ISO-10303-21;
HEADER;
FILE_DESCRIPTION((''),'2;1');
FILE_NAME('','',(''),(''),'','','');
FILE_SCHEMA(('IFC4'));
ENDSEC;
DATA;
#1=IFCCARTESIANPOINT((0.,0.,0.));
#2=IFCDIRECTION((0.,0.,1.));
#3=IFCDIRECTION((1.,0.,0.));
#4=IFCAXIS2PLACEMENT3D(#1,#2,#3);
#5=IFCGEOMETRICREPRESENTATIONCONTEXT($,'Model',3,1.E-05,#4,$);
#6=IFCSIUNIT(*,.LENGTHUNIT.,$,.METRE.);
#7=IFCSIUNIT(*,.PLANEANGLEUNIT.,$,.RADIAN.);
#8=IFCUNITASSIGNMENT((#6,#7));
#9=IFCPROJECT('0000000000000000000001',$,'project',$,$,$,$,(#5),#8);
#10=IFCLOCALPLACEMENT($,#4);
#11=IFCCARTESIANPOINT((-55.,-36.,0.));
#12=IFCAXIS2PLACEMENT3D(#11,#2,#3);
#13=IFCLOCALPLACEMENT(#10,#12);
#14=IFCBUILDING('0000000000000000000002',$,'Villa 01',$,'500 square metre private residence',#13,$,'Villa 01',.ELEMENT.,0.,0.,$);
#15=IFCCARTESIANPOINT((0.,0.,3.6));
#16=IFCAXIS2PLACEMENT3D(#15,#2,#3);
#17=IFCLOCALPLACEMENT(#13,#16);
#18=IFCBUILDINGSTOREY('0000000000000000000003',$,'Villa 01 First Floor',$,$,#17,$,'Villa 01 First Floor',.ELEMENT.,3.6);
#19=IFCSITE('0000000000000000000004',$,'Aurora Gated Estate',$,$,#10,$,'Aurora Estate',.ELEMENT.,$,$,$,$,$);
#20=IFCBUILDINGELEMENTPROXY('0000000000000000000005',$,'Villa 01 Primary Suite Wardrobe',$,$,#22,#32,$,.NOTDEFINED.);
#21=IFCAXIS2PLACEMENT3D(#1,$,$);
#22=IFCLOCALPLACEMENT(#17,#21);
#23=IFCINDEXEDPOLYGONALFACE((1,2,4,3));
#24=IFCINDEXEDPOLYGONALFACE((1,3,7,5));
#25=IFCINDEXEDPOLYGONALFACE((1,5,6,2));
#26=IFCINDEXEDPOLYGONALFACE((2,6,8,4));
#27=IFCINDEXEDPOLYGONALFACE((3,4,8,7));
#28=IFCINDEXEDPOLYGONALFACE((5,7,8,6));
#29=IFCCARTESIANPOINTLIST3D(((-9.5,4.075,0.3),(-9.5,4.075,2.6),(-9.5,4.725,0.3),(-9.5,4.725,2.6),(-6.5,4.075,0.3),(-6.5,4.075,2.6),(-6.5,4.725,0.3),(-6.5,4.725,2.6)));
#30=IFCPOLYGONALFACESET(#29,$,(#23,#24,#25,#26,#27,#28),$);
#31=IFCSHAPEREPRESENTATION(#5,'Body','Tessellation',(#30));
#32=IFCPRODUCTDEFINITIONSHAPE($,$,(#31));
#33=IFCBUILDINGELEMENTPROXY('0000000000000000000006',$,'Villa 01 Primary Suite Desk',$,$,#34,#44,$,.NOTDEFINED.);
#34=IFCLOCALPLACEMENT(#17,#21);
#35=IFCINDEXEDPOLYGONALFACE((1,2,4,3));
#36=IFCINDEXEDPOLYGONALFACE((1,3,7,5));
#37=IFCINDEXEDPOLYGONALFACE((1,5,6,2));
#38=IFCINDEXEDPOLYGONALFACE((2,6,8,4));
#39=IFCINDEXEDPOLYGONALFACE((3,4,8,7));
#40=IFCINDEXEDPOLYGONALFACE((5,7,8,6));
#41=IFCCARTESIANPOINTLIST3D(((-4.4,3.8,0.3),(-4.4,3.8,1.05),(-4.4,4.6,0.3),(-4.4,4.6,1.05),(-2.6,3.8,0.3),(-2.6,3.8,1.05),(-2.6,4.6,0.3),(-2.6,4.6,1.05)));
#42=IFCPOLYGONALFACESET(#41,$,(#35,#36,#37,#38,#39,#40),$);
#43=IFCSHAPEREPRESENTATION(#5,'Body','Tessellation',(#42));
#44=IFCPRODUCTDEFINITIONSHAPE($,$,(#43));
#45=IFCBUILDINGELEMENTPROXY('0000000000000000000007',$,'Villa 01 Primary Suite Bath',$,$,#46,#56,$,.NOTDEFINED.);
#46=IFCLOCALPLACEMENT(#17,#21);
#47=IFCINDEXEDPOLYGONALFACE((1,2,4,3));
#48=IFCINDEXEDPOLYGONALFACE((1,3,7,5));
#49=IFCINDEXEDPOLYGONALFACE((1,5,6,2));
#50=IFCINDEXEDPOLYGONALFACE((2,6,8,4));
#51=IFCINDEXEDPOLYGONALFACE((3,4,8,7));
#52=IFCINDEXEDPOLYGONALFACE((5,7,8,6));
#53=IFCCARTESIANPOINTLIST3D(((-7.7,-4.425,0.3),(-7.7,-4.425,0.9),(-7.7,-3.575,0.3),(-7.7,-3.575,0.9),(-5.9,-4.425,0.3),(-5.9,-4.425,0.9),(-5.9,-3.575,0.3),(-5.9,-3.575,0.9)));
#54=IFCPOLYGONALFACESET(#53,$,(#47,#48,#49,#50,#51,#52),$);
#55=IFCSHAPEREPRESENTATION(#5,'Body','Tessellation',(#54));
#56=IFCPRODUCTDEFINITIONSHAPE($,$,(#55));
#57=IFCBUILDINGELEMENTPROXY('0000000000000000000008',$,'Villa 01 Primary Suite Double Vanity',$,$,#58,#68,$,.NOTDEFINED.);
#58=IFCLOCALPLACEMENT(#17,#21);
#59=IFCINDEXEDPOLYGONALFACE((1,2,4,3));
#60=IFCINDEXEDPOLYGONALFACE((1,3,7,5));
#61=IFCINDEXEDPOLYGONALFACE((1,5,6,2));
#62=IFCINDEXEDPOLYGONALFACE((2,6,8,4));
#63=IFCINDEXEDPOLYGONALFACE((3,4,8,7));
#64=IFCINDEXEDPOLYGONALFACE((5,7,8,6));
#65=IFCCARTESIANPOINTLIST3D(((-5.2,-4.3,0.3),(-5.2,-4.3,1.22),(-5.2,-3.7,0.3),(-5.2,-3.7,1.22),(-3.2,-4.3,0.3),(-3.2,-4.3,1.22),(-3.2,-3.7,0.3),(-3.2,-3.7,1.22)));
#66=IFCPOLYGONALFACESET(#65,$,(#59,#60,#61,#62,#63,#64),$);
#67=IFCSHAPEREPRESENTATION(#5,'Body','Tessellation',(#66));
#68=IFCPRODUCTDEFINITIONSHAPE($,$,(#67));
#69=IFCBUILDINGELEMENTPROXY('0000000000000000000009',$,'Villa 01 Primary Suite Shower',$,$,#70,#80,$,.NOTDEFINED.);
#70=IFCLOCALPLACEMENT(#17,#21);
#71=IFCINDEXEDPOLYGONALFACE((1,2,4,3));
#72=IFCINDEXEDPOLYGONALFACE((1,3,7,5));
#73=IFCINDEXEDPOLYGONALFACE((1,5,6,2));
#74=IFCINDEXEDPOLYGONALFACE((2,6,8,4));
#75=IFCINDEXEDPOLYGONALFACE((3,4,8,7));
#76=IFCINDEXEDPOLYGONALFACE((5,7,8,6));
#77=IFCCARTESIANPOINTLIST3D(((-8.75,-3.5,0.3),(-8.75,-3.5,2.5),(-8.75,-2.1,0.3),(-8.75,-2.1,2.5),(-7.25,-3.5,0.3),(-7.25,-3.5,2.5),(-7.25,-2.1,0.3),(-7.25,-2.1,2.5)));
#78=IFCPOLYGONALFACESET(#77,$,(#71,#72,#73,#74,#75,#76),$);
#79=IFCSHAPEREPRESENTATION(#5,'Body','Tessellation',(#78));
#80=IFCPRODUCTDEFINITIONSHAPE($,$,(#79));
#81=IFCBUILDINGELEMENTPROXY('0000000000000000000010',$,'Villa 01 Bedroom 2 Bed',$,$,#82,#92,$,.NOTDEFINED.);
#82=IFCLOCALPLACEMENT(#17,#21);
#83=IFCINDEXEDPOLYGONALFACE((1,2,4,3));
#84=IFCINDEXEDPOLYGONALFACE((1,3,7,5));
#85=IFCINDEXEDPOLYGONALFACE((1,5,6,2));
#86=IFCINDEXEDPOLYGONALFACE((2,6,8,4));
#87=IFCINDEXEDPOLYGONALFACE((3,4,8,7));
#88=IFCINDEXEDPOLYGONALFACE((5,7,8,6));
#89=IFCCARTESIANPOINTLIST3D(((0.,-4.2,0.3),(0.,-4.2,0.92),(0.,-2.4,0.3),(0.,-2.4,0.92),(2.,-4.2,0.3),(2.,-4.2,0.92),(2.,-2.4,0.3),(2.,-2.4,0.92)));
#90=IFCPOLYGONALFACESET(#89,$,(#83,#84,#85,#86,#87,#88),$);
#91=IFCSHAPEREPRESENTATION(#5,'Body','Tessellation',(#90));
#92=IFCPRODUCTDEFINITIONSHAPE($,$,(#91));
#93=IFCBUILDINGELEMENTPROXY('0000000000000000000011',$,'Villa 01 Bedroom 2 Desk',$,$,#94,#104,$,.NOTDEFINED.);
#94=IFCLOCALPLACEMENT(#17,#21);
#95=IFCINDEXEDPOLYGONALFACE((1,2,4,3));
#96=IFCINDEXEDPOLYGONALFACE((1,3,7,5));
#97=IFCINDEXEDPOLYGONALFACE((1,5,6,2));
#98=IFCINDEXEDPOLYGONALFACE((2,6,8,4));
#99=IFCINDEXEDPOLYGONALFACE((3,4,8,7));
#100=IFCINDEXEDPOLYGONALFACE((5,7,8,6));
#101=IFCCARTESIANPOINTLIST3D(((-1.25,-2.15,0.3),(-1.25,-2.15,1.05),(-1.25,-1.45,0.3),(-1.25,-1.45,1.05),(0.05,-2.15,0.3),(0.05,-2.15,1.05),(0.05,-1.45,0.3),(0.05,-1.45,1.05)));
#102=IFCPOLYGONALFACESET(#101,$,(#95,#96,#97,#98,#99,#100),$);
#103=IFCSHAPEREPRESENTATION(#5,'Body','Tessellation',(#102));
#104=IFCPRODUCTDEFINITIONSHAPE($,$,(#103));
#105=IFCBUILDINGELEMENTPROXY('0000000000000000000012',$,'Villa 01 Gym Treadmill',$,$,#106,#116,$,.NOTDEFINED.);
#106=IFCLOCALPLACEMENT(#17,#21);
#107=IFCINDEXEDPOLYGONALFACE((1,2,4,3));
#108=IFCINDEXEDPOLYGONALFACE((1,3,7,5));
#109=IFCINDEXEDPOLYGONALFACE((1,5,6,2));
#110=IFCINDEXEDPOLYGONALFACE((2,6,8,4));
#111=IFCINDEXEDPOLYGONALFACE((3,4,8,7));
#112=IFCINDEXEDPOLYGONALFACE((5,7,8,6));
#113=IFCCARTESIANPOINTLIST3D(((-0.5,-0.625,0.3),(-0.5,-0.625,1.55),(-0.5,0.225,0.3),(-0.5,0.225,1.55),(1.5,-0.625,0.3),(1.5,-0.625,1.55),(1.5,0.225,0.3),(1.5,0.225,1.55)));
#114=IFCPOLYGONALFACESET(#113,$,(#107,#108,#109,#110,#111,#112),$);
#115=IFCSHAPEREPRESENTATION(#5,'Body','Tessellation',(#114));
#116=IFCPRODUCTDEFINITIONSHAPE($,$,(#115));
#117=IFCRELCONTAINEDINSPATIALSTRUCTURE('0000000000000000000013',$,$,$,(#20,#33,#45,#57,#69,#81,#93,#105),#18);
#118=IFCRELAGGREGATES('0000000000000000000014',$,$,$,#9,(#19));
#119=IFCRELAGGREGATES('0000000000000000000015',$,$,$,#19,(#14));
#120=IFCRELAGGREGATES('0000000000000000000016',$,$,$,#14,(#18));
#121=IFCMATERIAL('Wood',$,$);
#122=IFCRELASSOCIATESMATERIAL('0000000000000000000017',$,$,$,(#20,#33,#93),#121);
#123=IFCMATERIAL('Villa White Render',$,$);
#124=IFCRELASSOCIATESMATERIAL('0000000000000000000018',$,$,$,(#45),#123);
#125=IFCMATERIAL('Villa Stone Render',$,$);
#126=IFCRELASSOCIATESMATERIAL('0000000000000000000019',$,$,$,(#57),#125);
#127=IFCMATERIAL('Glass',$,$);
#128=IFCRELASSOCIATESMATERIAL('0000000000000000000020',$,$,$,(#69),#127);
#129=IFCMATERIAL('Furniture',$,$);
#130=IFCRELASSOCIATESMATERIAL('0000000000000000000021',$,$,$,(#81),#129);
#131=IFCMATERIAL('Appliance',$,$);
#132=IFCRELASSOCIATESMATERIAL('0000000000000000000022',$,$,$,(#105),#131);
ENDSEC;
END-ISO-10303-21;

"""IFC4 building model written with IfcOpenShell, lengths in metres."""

from ifc_helpers import new_model, si_unit, frame, origin_with_axes, origin_2d_with_axis, place, context, project, spatial, rectangle, extrude, material, element, save


model = new_model("IFC4")

# Units and contexts
model_context = context("Model", 3, precision=1e-05, world=origin_with_axes())
ifc_project = project(units=[si_unit("LENGTHUNIT", "METRE"), si_unit("PLANEANGLEUNIT", "RADIAN")], contexts=[model_context])

# Site, building, storey
site_placement = place(None, origin_with_axes())
site = spatial("IfcSite", under=ifc_project, at=site_placement, Name="Aurora Gated Estate", LongName="Aurora Estate", CompositionType="ELEMENT")
building_placement = place(site_placement, frame((-55.0, -36.0, 0.0), z_axis=(0.0, 0.0, 1.0), x_axis=(1.0, 0.0, 0.0)))
building = spatial("IfcBuilding", under=site, at=building_placement, Name="Villa 01", ObjectType="500 square metre private residence", LongName="Villa 01", CompositionType="ELEMENT", ElevationOfRefHeight=0.0, ElevationOfTerrain=0.0)
storey_placement = place(building_placement, frame((0.0, 0.0, 3.6), z_axis=(0.0, 0.0, 1.0), x_axis=(1.0, 0.0, 0.0)))
storey = spatial("IfcBuildingStorey", under=building, at=storey_placement, Name="Villa 01 First Floor", LongName="Villa 01 First Floor", CompositionType="ELEMENT", Elevation=3.6)

# Shared definitions
ifc_material_1 = material(Name="Villa White Render")

# Building element proxies
ifc_material_2 = material(Name="Glass")
ifc_material_3 = material(Name="Furniture")
ifc_material_4 = material(Name="Wood")
proxy_1_placement = place(storey_placement, frame((-8.0, 4.4, 0.3), z_axis=(0.0, 0.0, 1.0), x_axis=(1.0, 0.0, 0.0)))
element("IfcBuildingElementProxy", 1, at=proxy_1_placement, inside=storey, material=ifc_material_4, Name="Villa 01 Primary Suite Wardrobe", PredefinedType="NOTDEFINED", context=model_context, shape_type="SweptSolid", body=[
    extrude(rectangle(XDim=3.0, YDim=0.65, at=origin_2d_with_axis()), origin_with_axes(), (0.0, 0.0, 1.0), 2.3),
])
proxy_2_placement = place(storey_placement, frame((-3.5, 4.2, 0.3), z_axis=(0.0, 0.0, 1.0), x_axis=(1.0, 0.0, 0.0)))
element("IfcBuildingElementProxy", 2, at=proxy_2_placement, inside=storey, material=ifc_material_4, Name="Villa 01 Primary Suite Desk", PredefinedType="NOTDEFINED", context=model_context, shape_type="SweptSolid", body=[
    extrude(rectangle(XDim=1.8, YDim=0.8, at=origin_2d_with_axis()), origin_with_axes(), (0.0, 0.0, 1.0), 0.75),
])
proxy_3_placement = place(storey_placement, frame((-6.8, -4.0, 0.3), z_axis=(0.0, 0.0, 1.0), x_axis=(1.0, 0.0, 0.0)))
element("IfcBuildingElementProxy", 3, at=proxy_3_placement, inside=storey, material=ifc_material_1, Name="Villa 01 Primary Suite Bath", PredefinedType="NOTDEFINED", context=model_context, shape_type="SweptSolid", body=[
    extrude(rectangle(XDim=1.8, YDim=0.85, at=origin_2d_with_axis()), origin_with_axes(), (0.0, 0.0, 1.0), 0.6),
])
ifc_material_5 = material(Name="Villa Stone Render")
proxy_4_placement = place(storey_placement, frame((-4.2, -4.0, 0.3), z_axis=(0.0, 0.0, 1.0), x_axis=(1.0, 0.0, 0.0)))
element("IfcBuildingElementProxy", 4, at=proxy_4_placement, inside=storey, material=ifc_material_5, Name="Villa 01 Primary Suite Double Vanity", PredefinedType="NOTDEFINED", context=model_context, shape_type="SweptSolid", body=[
    extrude(rectangle(XDim=2.0, YDim=0.6, at=origin_2d_with_axis()), origin_with_axes(), (0.0, 0.0, 1.0), 0.92),
])
proxy_5_placement = place(storey_placement, frame((-8.0, -2.8, 0.3), z_axis=(0.0, 0.0, 1.0), x_axis=(1.0, 0.0, 0.0)))
element("IfcBuildingElementProxy", 5, at=proxy_5_placement, inside=storey, material=ifc_material_2, Name="Villa 01 Primary Suite Shower", PredefinedType="NOTDEFINED", context=model_context, shape_type="SweptSolid", body=[
    extrude(rectangle(XDim=1.5, YDim=1.4, at=origin_2d_with_axis()), origin_with_axes(), (0.0, 0.0, 1.0), 2.2),
])
proxy_6_placement = place(storey_placement, frame((1.0, -3.3, 0.3), z_axis=(0.0, 0.0, 1.0), x_axis=(1.0, 0.0, 0.0)))
element("IfcBuildingElementProxy", 6, at=proxy_6_placement, inside=storey, material=ifc_material_3, Name="Villa 01 Bedroom 2 Bed", PredefinedType="NOTDEFINED", context=model_context, shape_type="SweptSolid", body=[
    extrude(rectangle(XDim=2.0, YDim=1.8, at=origin_2d_with_axis()), origin_with_axes(), (0.0, 0.0, 1.0), 0.62),
])
proxy_7_placement = place(storey_placement, frame((-0.6, -1.8, 0.3), z_axis=(0.0, 0.0, 1.0), x_axis=(1.0, 0.0, 0.0)))
element("IfcBuildingElementProxy", 7, at=proxy_7_placement, inside=storey, material=ifc_material_4, Name="Villa 01 Bedroom 2 Desk", PredefinedType="NOTDEFINED", context=model_context, shape_type="SweptSolid", body=[
    extrude(rectangle(XDim=1.3, YDim=0.7, at=origin_2d_with_axis()), origin_with_axes(), (0.0, 0.0, 1.0), 0.75),
])
ifc_material_6 = material(Name="Appliance")
proxy_8_placement = place(storey_placement, frame((0.5, -0.2, 0.3), z_axis=(0.0, 0.0, 1.0), x_axis=(1.0, 0.0, 0.0)))
element("IfcBuildingElementProxy", 8, at=proxy_8_placement, inside=storey, material=ifc_material_6, Name="Villa 01 Gym Treadmill", PredefinedType="NOTDEFINED", context=model_context, shape_type="SweptSolid", body=[
    extrude(rectangle(XDim=2.0, YDim=0.85, at=origin_2d_with_axis()), origin_with_axes(), (0.0, 0.0, 1.0), 1.25),
])

save(model, "model.ifc")
